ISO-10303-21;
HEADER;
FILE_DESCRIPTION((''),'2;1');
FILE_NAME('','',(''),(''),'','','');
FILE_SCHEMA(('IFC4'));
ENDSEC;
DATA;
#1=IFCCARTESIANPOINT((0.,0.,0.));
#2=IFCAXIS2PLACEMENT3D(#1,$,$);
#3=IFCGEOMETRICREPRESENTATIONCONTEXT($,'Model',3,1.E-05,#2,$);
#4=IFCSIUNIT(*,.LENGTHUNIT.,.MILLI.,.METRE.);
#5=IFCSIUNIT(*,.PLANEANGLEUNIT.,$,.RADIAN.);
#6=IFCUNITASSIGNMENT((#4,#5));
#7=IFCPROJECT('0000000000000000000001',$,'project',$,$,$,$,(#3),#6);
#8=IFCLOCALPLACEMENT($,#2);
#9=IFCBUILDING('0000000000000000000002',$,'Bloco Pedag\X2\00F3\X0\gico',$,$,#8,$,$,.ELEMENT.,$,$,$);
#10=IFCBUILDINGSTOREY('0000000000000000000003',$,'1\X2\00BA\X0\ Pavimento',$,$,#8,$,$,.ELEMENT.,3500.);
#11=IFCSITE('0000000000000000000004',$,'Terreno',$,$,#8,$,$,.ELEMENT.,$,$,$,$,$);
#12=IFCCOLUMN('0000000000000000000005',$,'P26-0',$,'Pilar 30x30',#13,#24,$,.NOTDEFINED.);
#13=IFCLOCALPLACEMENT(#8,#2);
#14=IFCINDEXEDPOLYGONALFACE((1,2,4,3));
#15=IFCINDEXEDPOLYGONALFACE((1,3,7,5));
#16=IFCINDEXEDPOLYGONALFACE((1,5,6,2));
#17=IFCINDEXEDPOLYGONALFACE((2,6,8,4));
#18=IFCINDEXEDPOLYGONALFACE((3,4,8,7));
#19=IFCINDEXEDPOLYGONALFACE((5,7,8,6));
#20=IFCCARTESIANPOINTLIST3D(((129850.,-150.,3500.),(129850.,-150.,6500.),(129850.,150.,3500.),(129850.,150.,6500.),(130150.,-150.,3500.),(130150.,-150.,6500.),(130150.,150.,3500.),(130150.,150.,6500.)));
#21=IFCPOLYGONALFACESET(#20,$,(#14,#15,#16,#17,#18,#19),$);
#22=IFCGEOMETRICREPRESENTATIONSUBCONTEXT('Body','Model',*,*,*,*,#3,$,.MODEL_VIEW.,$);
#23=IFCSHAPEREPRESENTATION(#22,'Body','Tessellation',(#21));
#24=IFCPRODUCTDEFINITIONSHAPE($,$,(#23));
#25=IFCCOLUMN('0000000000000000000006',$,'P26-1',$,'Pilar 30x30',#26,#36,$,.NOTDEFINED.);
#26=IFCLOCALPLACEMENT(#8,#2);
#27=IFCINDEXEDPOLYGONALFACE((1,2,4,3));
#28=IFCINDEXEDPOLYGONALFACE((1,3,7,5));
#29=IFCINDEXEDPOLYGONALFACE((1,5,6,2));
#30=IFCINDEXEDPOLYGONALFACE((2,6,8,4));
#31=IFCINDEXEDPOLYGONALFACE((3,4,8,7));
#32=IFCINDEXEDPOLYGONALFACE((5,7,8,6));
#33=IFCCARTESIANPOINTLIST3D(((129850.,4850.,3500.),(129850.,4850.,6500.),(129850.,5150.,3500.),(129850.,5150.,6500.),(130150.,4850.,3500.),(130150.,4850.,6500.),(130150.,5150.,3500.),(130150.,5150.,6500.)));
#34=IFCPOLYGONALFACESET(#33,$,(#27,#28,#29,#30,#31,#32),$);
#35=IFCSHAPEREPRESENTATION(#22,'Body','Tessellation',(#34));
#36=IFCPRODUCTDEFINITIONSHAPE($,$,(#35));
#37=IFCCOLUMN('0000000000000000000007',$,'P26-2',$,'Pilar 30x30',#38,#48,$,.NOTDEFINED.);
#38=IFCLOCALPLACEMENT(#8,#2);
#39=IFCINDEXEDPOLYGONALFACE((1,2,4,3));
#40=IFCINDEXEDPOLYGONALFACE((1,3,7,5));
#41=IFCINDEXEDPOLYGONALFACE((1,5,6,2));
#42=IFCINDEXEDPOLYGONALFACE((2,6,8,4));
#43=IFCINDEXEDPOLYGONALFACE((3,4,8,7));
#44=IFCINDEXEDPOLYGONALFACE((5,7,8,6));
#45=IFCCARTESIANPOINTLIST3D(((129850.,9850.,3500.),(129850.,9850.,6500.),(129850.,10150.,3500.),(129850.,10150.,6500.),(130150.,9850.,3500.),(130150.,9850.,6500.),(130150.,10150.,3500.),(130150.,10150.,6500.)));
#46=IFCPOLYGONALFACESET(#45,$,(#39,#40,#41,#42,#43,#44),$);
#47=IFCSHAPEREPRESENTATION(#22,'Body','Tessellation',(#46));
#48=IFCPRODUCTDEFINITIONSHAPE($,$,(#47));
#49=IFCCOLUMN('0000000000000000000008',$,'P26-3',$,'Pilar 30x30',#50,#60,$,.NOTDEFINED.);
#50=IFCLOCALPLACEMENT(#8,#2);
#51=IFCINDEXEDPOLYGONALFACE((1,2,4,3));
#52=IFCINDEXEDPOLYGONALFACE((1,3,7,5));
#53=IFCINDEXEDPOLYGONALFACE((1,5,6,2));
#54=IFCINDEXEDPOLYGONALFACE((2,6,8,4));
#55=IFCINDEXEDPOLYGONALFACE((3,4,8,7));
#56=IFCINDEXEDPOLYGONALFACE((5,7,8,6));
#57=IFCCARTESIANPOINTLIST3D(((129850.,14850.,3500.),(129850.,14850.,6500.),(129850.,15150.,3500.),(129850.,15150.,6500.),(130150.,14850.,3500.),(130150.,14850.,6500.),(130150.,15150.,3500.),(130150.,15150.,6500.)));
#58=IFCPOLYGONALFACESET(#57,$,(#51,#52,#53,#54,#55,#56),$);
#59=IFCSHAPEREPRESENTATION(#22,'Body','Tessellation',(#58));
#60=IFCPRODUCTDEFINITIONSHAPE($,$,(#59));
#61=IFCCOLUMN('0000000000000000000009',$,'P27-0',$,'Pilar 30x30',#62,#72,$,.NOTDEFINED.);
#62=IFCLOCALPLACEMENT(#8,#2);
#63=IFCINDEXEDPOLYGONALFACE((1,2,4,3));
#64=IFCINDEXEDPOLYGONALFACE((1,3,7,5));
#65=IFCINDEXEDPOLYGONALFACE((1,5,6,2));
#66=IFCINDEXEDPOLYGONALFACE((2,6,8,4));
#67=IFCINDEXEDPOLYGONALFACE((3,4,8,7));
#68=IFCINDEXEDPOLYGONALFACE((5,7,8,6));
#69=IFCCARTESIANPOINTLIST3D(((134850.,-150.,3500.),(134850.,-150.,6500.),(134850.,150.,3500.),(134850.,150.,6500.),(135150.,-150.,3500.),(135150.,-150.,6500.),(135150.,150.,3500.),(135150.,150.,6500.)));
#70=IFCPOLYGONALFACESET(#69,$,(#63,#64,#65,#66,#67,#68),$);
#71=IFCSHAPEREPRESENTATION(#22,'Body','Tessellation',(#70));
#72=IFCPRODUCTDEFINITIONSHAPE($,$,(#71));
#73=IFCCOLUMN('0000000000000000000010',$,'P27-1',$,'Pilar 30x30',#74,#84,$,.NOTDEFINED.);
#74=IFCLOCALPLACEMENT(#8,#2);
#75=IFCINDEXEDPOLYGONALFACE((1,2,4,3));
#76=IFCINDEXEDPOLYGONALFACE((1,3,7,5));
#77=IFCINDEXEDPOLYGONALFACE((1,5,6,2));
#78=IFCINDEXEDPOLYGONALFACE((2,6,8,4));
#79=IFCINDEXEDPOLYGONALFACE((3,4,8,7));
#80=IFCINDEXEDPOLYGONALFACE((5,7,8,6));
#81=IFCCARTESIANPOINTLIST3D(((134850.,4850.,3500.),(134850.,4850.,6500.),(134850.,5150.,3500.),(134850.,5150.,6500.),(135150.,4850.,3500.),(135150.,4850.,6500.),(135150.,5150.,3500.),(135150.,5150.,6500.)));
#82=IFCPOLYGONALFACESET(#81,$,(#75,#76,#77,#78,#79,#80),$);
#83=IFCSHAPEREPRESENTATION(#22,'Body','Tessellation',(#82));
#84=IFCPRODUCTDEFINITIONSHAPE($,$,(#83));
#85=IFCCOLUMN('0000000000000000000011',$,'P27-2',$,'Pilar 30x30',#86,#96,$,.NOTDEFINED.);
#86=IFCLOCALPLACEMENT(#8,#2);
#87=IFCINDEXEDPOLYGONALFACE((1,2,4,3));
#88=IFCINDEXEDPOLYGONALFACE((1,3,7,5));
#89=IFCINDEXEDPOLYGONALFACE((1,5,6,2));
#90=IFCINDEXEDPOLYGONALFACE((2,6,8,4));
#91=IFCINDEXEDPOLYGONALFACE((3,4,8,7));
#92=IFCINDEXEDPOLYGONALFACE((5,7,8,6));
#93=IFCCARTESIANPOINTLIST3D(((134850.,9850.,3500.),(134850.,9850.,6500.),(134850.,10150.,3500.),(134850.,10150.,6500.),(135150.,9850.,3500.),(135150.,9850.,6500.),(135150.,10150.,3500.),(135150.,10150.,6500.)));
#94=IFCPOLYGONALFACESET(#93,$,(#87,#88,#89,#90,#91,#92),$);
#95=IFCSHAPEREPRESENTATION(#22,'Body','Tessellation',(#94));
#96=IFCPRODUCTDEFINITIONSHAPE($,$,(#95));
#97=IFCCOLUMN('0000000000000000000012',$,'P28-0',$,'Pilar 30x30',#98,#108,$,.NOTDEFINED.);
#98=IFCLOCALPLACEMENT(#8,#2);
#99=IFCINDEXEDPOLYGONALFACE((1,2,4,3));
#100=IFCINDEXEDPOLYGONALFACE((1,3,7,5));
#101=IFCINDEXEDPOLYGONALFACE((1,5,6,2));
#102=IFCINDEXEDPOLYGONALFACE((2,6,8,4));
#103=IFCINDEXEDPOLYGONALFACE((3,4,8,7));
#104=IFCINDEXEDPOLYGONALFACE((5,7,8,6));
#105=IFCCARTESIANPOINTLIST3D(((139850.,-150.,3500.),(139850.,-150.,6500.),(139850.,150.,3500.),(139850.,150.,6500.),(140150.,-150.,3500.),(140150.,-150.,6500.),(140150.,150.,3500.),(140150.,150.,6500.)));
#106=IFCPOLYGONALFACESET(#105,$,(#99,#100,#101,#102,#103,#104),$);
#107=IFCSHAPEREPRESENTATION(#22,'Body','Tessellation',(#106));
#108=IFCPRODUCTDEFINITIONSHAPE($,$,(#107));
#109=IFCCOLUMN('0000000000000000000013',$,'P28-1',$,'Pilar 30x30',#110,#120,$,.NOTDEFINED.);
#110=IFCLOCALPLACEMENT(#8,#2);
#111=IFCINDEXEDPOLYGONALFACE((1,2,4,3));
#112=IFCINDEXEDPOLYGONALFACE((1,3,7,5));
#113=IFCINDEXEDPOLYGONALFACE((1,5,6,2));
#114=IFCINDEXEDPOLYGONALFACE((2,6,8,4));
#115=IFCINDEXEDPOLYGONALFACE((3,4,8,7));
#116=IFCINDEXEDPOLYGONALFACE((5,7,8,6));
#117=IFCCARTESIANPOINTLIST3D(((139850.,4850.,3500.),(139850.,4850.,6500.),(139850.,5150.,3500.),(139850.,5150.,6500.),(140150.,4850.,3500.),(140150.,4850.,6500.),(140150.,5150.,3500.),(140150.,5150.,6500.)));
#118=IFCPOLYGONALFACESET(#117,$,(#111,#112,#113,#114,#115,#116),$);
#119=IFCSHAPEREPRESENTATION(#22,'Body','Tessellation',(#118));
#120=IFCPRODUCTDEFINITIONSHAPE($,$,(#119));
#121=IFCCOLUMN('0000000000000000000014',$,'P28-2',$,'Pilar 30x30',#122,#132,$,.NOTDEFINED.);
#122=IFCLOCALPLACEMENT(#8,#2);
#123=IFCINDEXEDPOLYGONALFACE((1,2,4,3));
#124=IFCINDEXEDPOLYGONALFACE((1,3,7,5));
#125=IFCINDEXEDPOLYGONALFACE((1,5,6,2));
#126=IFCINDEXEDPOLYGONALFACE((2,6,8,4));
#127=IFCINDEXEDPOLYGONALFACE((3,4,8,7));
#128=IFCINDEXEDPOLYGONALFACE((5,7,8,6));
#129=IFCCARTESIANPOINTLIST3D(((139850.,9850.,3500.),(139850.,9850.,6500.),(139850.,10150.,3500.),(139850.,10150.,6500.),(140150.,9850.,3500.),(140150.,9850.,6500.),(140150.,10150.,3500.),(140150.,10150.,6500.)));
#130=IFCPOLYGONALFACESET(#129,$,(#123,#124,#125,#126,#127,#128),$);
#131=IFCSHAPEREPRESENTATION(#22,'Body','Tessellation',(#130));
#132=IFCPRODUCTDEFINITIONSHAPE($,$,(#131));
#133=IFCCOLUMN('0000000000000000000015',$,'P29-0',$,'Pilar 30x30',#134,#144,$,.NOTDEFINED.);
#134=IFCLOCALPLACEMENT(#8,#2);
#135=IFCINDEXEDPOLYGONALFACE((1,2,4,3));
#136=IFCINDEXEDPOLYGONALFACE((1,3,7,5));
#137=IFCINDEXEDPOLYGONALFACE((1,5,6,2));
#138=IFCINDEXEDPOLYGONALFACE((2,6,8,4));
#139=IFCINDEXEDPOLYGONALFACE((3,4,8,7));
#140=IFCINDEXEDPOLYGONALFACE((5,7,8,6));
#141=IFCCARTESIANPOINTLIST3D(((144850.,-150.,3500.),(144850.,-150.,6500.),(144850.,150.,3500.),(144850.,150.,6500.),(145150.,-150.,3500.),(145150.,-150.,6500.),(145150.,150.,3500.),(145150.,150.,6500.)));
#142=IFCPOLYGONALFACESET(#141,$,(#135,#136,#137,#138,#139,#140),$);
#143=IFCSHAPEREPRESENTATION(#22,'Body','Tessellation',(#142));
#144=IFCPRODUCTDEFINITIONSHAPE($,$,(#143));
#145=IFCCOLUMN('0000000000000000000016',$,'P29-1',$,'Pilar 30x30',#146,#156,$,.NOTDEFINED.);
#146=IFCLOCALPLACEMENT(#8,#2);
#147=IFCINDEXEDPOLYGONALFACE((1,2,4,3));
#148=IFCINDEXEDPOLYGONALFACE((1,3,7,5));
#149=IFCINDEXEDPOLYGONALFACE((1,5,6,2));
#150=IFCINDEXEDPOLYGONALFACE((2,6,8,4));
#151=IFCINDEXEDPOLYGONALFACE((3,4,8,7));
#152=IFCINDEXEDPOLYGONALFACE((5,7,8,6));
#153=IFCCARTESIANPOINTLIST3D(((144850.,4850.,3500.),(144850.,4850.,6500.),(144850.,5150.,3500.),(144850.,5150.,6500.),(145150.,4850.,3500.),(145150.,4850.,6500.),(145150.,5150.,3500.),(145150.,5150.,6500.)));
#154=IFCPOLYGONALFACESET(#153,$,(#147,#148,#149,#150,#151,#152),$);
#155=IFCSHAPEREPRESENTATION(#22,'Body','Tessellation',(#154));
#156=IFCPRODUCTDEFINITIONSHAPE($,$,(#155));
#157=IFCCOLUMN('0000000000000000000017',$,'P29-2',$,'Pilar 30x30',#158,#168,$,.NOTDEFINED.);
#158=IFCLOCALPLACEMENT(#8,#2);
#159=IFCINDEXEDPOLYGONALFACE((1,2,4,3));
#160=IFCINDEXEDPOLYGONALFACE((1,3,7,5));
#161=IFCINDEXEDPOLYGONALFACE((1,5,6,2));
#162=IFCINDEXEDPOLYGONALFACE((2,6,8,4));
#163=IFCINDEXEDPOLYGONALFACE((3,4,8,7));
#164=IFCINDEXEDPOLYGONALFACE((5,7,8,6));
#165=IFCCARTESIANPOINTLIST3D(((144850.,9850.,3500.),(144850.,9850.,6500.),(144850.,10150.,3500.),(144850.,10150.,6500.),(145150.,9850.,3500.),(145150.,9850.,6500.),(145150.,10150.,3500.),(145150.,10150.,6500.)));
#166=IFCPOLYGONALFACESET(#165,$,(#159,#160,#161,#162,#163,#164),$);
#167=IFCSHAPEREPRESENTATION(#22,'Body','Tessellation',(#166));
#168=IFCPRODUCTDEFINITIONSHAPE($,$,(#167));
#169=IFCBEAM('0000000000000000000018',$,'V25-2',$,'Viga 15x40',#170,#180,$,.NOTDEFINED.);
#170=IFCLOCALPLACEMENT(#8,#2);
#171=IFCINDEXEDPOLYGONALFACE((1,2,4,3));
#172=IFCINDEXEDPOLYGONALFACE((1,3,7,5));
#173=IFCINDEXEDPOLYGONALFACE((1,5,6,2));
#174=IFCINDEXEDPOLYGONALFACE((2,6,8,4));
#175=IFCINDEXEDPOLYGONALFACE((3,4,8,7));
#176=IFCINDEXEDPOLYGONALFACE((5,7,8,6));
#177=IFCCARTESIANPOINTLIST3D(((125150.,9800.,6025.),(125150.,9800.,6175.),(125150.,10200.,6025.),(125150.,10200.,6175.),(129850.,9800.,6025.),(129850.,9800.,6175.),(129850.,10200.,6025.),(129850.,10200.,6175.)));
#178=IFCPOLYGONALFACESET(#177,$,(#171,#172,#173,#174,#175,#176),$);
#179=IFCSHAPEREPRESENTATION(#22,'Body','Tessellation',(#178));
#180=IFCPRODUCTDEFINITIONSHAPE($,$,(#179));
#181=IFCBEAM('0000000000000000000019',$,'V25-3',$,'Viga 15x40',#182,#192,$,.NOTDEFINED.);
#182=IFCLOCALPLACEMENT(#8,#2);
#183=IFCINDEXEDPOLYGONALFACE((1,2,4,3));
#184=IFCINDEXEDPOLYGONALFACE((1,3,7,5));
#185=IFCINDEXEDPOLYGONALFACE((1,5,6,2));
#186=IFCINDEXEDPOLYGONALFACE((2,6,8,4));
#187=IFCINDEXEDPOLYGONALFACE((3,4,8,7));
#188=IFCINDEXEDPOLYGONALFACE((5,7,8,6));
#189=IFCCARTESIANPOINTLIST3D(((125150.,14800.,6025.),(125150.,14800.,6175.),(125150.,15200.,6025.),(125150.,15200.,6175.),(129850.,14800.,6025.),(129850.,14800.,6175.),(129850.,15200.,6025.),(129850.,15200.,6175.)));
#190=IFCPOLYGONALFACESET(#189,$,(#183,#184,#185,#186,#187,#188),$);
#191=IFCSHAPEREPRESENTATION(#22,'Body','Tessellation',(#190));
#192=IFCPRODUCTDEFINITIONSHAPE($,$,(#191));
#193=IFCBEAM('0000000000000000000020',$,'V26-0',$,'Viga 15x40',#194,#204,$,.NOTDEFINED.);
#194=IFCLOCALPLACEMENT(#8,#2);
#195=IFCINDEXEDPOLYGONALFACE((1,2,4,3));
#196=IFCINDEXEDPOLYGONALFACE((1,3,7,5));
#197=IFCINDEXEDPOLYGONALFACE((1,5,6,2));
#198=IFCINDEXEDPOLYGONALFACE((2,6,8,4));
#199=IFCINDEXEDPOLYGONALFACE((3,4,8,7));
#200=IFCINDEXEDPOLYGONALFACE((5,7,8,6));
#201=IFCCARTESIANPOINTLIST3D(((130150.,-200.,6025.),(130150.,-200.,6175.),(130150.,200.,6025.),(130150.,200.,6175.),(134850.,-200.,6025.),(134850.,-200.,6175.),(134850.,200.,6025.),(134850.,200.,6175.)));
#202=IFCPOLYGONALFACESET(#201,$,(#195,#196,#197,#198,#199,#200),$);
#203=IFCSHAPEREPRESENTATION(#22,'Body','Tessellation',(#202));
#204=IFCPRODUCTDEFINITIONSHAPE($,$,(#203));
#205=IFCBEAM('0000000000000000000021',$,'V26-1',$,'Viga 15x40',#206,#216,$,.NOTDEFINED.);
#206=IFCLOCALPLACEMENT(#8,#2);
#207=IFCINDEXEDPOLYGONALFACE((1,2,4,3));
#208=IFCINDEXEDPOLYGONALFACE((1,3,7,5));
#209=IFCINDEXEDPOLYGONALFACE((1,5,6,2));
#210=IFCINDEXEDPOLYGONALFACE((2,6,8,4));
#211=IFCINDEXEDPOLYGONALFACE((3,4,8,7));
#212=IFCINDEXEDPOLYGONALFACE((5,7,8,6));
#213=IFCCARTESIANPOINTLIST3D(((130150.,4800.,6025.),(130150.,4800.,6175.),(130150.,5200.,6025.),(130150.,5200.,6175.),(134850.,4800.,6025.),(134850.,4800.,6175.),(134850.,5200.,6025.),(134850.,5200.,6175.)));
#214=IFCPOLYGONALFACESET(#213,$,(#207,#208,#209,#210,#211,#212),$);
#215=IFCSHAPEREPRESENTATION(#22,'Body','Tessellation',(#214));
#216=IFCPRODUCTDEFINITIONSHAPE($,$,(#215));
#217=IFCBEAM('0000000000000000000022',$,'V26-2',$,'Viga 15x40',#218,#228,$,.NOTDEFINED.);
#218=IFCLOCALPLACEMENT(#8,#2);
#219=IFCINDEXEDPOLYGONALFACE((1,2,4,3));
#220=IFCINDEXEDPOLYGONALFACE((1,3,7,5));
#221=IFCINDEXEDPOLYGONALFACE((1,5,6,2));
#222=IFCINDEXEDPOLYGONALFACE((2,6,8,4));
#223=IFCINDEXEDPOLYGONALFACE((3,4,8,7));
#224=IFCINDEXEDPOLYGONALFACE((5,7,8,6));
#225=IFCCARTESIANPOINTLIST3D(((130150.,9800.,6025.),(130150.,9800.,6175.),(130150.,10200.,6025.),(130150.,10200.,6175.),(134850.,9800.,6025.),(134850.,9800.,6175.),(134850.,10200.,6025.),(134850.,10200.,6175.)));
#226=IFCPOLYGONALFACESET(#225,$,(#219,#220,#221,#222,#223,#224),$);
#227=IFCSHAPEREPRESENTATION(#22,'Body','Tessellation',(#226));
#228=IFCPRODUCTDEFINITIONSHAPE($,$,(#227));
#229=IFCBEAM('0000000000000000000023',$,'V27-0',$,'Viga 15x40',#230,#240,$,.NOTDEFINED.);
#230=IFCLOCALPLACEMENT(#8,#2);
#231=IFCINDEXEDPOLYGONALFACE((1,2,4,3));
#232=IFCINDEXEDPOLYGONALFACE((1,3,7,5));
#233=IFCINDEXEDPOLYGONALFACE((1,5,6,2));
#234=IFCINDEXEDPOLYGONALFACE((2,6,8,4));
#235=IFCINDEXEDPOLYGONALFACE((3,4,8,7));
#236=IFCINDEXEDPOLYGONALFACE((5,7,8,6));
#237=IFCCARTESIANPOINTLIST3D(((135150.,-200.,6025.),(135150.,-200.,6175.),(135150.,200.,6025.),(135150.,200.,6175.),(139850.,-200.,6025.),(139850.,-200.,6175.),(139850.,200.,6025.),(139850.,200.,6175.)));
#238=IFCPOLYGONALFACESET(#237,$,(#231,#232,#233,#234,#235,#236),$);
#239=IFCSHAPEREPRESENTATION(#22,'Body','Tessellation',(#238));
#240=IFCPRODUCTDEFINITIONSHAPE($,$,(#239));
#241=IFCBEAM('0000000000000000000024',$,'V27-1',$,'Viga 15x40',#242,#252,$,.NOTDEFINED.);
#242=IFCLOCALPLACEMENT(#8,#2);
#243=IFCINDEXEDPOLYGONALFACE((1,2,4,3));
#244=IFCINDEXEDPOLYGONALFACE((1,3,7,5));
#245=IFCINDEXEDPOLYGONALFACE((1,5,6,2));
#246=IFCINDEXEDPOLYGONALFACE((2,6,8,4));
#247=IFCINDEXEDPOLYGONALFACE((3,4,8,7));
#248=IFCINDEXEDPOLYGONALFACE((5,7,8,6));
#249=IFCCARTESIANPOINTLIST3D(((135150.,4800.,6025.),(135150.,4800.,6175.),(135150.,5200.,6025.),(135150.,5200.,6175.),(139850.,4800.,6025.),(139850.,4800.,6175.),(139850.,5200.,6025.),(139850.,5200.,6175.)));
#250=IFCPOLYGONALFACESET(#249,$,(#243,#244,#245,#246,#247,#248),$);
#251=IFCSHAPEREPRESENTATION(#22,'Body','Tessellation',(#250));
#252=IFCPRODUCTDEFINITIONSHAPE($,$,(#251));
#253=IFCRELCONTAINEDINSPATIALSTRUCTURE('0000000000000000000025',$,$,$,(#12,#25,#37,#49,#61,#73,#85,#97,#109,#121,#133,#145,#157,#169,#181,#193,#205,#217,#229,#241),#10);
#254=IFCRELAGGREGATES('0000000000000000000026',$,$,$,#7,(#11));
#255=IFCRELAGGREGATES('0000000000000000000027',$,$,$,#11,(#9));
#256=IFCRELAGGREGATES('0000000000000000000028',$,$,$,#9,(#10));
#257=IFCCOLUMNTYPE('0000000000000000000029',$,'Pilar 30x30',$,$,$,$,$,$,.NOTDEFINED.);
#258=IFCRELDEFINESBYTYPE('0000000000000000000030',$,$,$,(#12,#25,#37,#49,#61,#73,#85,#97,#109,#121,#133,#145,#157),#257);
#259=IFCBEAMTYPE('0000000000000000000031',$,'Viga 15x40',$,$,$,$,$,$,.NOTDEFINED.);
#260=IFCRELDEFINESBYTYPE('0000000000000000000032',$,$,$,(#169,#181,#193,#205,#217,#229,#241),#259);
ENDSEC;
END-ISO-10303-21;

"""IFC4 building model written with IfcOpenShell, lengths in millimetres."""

from ifc_helpers import new_model, si_unit, frame, origin, origin_2d, place, context, subcontext, project, spatial, rectangle, extrude, type_object, element, save


model = new_model("IFC4")

# Units and contexts
model_context = context("Model", 3, precision=1e-05, world=origin())
body_context = subcontext(model_context, "Body", "Model", "MODEL_VIEW")
ifc_project = project(units=[si_unit("LENGTHUNIT", "METRE", prefix="MILLI"), si_unit("PLANEANGLEUNIT", "RADIAN")], contexts=[model_context])

# Site, building, storey
placement = place(None, origin())
site = spatial("IfcSite", under=ifc_project, at=placement, Name="Terreno", CompositionType="ELEMENT")
building = spatial("IfcBuilding", under=site, at=placement, Name="Bloco Pedagógico", CompositionType="ELEMENT")
storey = spatial("IfcBuildingStorey", under=building, at=placement, Name="1º Pavimento", CompositionType="ELEMENT", Elevation=3500.0)

# Columns
column_type = type_object("IfcColumnType", Name="Pilar 30x30", PredefinedType="NOTDEFINED")
for number, where, z_axis, x_axis, name in (
    (1, (130000.0, 0.0, 3500.0), (0.0, 0.0, 1.0), (1.0, 0.0, 0.0), "P26-0"),
    (2, (130000.0, 5000.0, 3500.0), (0.0, 0.0, 1.0), (1.0, 0.0, 0.0), "P26-1"),
    (3, (130000.0, 10000.0, 3500.0), (0.0, 0.0, 1.0), (1.0, 0.0, 0.0), "P26-2"),
    (4, (130000.0, 15000.0, 3500.0), (0.0, 0.0, 1.0), (1.0, 0.0, 0.0), "P26-3"),
    (5, (135000.0, 0.0, 3500.0), (0.0, 0.0, 1.0), (1.0, 0.0, 0.0), "P27-0"),
    (6, (135000.0, 5000.0, 3500.0), (0.0, 0.0, 1.0), (1.0, 0.0, 0.0), "P27-1"),
    (7, (135000.0, 10000.0, 3500.0), (0.0, 0.0, 1.0), (1.0, 0.0, 0.0), "P27-2"),
    (8, (140000.0, 0.0, 3500.0), (0.0, 0.0, 1.0), (1.0, 0.0, 0.0), "P28-0"),
    (9, (140000.0, 5000.0, 3500.0), (0.0, 0.0, 1.0), (1.0, 0.0, 0.0), "P28-1"),
    (10, (140000.0, 10000.0, 3500.0), (0.0, 0.0, 1.0), (1.0, 0.0, 0.0), "P28-2"),
    (11, (145000.0, 0.0, 3500.0), (0.0, 0.0, 1.0), (1.0, 0.0, 0.0), "P29-0"),
    (12, (145000.0, 5000.0, 3500.0), (0.0, 0.0, 1.0), (1.0, 0.0, 0.0), "P29-1"),
    (13, (145000.0, 10000.0, 3500.0), (0.0, 0.0, 1.0), (1.0, 0.0, 0.0), "P29-2"),
):
    element("IfcColumn", number, at=place(None, frame(where, z_axis=z_axis, x_axis=x_axis)), inside=storey, type_object=column_type, Name=name, ObjectType="Pilar 30x30", PredefinedType="NOTDEFINED", context=body_context, shape_type="SweptSolid", body=[
        extrude(rectangle(XDim=300.0, YDim=300.0, at=origin_2d()), None, (0.0, 0.0, 1.0), 3000.0),
    ])

# Beams
beam_type = type_object("IfcBeamType", Name="Viga 15x40", PredefinedType="NOTDEFINED")
for number, where, z_axis, x_axis, name in (
    (14, (125150.0, 10000.0, 6100.0), (1.0, 0.0, 0.0), (0.0, 1.0, 0.0), "V25-2"),
    (15, (125150.0, 15000.0, 6100.0), (1.0, 0.0, 0.0), (0.0, 1.0, 0.0), "V25-3"),
    (16, (130150.0, 0.0, 6100.0), (1.0, 0.0, 0.0), (0.0, 1.0, 0.0), "V26-0"),
    (17, (130150.0, 5000.0, 6100.0), (1.0, 0.0, 0.0), (0.0, 1.0, 0.0), "V26-1"),
    (18, (130150.0, 10000.0, 6100.0), (1.0, 0.0, 0.0), (0.0, 1.0, 0.0), "V26-2"),
    (19, (135150.0, 0.0, 6100.0), (1.0, 0.0, 0.0), (0.0, 1.0, 0.0), "V27-0"),
    (20, (135150.0, 5000.0, 6100.0), (1.0, 0.0, 0.0), (0.0, 1.0, 0.0), "V27-1"),
):
    element("IfcBeam", number, at=place(None, frame(where, z_axis=z_axis, x_axis=x_axis)), inside=storey, type_object=beam_type, Name=name, ObjectType="Viga 15x40", PredefinedType="NOTDEFINED", context=body_context, shape_type="SweptSolid", body=[
        extrude(rectangle(XDim=400.0, YDim=150.0, at=origin_2d()), None, (0.0, 0.0, 1.0), 4700.0),
    ])

save(model, "model.ifc")
